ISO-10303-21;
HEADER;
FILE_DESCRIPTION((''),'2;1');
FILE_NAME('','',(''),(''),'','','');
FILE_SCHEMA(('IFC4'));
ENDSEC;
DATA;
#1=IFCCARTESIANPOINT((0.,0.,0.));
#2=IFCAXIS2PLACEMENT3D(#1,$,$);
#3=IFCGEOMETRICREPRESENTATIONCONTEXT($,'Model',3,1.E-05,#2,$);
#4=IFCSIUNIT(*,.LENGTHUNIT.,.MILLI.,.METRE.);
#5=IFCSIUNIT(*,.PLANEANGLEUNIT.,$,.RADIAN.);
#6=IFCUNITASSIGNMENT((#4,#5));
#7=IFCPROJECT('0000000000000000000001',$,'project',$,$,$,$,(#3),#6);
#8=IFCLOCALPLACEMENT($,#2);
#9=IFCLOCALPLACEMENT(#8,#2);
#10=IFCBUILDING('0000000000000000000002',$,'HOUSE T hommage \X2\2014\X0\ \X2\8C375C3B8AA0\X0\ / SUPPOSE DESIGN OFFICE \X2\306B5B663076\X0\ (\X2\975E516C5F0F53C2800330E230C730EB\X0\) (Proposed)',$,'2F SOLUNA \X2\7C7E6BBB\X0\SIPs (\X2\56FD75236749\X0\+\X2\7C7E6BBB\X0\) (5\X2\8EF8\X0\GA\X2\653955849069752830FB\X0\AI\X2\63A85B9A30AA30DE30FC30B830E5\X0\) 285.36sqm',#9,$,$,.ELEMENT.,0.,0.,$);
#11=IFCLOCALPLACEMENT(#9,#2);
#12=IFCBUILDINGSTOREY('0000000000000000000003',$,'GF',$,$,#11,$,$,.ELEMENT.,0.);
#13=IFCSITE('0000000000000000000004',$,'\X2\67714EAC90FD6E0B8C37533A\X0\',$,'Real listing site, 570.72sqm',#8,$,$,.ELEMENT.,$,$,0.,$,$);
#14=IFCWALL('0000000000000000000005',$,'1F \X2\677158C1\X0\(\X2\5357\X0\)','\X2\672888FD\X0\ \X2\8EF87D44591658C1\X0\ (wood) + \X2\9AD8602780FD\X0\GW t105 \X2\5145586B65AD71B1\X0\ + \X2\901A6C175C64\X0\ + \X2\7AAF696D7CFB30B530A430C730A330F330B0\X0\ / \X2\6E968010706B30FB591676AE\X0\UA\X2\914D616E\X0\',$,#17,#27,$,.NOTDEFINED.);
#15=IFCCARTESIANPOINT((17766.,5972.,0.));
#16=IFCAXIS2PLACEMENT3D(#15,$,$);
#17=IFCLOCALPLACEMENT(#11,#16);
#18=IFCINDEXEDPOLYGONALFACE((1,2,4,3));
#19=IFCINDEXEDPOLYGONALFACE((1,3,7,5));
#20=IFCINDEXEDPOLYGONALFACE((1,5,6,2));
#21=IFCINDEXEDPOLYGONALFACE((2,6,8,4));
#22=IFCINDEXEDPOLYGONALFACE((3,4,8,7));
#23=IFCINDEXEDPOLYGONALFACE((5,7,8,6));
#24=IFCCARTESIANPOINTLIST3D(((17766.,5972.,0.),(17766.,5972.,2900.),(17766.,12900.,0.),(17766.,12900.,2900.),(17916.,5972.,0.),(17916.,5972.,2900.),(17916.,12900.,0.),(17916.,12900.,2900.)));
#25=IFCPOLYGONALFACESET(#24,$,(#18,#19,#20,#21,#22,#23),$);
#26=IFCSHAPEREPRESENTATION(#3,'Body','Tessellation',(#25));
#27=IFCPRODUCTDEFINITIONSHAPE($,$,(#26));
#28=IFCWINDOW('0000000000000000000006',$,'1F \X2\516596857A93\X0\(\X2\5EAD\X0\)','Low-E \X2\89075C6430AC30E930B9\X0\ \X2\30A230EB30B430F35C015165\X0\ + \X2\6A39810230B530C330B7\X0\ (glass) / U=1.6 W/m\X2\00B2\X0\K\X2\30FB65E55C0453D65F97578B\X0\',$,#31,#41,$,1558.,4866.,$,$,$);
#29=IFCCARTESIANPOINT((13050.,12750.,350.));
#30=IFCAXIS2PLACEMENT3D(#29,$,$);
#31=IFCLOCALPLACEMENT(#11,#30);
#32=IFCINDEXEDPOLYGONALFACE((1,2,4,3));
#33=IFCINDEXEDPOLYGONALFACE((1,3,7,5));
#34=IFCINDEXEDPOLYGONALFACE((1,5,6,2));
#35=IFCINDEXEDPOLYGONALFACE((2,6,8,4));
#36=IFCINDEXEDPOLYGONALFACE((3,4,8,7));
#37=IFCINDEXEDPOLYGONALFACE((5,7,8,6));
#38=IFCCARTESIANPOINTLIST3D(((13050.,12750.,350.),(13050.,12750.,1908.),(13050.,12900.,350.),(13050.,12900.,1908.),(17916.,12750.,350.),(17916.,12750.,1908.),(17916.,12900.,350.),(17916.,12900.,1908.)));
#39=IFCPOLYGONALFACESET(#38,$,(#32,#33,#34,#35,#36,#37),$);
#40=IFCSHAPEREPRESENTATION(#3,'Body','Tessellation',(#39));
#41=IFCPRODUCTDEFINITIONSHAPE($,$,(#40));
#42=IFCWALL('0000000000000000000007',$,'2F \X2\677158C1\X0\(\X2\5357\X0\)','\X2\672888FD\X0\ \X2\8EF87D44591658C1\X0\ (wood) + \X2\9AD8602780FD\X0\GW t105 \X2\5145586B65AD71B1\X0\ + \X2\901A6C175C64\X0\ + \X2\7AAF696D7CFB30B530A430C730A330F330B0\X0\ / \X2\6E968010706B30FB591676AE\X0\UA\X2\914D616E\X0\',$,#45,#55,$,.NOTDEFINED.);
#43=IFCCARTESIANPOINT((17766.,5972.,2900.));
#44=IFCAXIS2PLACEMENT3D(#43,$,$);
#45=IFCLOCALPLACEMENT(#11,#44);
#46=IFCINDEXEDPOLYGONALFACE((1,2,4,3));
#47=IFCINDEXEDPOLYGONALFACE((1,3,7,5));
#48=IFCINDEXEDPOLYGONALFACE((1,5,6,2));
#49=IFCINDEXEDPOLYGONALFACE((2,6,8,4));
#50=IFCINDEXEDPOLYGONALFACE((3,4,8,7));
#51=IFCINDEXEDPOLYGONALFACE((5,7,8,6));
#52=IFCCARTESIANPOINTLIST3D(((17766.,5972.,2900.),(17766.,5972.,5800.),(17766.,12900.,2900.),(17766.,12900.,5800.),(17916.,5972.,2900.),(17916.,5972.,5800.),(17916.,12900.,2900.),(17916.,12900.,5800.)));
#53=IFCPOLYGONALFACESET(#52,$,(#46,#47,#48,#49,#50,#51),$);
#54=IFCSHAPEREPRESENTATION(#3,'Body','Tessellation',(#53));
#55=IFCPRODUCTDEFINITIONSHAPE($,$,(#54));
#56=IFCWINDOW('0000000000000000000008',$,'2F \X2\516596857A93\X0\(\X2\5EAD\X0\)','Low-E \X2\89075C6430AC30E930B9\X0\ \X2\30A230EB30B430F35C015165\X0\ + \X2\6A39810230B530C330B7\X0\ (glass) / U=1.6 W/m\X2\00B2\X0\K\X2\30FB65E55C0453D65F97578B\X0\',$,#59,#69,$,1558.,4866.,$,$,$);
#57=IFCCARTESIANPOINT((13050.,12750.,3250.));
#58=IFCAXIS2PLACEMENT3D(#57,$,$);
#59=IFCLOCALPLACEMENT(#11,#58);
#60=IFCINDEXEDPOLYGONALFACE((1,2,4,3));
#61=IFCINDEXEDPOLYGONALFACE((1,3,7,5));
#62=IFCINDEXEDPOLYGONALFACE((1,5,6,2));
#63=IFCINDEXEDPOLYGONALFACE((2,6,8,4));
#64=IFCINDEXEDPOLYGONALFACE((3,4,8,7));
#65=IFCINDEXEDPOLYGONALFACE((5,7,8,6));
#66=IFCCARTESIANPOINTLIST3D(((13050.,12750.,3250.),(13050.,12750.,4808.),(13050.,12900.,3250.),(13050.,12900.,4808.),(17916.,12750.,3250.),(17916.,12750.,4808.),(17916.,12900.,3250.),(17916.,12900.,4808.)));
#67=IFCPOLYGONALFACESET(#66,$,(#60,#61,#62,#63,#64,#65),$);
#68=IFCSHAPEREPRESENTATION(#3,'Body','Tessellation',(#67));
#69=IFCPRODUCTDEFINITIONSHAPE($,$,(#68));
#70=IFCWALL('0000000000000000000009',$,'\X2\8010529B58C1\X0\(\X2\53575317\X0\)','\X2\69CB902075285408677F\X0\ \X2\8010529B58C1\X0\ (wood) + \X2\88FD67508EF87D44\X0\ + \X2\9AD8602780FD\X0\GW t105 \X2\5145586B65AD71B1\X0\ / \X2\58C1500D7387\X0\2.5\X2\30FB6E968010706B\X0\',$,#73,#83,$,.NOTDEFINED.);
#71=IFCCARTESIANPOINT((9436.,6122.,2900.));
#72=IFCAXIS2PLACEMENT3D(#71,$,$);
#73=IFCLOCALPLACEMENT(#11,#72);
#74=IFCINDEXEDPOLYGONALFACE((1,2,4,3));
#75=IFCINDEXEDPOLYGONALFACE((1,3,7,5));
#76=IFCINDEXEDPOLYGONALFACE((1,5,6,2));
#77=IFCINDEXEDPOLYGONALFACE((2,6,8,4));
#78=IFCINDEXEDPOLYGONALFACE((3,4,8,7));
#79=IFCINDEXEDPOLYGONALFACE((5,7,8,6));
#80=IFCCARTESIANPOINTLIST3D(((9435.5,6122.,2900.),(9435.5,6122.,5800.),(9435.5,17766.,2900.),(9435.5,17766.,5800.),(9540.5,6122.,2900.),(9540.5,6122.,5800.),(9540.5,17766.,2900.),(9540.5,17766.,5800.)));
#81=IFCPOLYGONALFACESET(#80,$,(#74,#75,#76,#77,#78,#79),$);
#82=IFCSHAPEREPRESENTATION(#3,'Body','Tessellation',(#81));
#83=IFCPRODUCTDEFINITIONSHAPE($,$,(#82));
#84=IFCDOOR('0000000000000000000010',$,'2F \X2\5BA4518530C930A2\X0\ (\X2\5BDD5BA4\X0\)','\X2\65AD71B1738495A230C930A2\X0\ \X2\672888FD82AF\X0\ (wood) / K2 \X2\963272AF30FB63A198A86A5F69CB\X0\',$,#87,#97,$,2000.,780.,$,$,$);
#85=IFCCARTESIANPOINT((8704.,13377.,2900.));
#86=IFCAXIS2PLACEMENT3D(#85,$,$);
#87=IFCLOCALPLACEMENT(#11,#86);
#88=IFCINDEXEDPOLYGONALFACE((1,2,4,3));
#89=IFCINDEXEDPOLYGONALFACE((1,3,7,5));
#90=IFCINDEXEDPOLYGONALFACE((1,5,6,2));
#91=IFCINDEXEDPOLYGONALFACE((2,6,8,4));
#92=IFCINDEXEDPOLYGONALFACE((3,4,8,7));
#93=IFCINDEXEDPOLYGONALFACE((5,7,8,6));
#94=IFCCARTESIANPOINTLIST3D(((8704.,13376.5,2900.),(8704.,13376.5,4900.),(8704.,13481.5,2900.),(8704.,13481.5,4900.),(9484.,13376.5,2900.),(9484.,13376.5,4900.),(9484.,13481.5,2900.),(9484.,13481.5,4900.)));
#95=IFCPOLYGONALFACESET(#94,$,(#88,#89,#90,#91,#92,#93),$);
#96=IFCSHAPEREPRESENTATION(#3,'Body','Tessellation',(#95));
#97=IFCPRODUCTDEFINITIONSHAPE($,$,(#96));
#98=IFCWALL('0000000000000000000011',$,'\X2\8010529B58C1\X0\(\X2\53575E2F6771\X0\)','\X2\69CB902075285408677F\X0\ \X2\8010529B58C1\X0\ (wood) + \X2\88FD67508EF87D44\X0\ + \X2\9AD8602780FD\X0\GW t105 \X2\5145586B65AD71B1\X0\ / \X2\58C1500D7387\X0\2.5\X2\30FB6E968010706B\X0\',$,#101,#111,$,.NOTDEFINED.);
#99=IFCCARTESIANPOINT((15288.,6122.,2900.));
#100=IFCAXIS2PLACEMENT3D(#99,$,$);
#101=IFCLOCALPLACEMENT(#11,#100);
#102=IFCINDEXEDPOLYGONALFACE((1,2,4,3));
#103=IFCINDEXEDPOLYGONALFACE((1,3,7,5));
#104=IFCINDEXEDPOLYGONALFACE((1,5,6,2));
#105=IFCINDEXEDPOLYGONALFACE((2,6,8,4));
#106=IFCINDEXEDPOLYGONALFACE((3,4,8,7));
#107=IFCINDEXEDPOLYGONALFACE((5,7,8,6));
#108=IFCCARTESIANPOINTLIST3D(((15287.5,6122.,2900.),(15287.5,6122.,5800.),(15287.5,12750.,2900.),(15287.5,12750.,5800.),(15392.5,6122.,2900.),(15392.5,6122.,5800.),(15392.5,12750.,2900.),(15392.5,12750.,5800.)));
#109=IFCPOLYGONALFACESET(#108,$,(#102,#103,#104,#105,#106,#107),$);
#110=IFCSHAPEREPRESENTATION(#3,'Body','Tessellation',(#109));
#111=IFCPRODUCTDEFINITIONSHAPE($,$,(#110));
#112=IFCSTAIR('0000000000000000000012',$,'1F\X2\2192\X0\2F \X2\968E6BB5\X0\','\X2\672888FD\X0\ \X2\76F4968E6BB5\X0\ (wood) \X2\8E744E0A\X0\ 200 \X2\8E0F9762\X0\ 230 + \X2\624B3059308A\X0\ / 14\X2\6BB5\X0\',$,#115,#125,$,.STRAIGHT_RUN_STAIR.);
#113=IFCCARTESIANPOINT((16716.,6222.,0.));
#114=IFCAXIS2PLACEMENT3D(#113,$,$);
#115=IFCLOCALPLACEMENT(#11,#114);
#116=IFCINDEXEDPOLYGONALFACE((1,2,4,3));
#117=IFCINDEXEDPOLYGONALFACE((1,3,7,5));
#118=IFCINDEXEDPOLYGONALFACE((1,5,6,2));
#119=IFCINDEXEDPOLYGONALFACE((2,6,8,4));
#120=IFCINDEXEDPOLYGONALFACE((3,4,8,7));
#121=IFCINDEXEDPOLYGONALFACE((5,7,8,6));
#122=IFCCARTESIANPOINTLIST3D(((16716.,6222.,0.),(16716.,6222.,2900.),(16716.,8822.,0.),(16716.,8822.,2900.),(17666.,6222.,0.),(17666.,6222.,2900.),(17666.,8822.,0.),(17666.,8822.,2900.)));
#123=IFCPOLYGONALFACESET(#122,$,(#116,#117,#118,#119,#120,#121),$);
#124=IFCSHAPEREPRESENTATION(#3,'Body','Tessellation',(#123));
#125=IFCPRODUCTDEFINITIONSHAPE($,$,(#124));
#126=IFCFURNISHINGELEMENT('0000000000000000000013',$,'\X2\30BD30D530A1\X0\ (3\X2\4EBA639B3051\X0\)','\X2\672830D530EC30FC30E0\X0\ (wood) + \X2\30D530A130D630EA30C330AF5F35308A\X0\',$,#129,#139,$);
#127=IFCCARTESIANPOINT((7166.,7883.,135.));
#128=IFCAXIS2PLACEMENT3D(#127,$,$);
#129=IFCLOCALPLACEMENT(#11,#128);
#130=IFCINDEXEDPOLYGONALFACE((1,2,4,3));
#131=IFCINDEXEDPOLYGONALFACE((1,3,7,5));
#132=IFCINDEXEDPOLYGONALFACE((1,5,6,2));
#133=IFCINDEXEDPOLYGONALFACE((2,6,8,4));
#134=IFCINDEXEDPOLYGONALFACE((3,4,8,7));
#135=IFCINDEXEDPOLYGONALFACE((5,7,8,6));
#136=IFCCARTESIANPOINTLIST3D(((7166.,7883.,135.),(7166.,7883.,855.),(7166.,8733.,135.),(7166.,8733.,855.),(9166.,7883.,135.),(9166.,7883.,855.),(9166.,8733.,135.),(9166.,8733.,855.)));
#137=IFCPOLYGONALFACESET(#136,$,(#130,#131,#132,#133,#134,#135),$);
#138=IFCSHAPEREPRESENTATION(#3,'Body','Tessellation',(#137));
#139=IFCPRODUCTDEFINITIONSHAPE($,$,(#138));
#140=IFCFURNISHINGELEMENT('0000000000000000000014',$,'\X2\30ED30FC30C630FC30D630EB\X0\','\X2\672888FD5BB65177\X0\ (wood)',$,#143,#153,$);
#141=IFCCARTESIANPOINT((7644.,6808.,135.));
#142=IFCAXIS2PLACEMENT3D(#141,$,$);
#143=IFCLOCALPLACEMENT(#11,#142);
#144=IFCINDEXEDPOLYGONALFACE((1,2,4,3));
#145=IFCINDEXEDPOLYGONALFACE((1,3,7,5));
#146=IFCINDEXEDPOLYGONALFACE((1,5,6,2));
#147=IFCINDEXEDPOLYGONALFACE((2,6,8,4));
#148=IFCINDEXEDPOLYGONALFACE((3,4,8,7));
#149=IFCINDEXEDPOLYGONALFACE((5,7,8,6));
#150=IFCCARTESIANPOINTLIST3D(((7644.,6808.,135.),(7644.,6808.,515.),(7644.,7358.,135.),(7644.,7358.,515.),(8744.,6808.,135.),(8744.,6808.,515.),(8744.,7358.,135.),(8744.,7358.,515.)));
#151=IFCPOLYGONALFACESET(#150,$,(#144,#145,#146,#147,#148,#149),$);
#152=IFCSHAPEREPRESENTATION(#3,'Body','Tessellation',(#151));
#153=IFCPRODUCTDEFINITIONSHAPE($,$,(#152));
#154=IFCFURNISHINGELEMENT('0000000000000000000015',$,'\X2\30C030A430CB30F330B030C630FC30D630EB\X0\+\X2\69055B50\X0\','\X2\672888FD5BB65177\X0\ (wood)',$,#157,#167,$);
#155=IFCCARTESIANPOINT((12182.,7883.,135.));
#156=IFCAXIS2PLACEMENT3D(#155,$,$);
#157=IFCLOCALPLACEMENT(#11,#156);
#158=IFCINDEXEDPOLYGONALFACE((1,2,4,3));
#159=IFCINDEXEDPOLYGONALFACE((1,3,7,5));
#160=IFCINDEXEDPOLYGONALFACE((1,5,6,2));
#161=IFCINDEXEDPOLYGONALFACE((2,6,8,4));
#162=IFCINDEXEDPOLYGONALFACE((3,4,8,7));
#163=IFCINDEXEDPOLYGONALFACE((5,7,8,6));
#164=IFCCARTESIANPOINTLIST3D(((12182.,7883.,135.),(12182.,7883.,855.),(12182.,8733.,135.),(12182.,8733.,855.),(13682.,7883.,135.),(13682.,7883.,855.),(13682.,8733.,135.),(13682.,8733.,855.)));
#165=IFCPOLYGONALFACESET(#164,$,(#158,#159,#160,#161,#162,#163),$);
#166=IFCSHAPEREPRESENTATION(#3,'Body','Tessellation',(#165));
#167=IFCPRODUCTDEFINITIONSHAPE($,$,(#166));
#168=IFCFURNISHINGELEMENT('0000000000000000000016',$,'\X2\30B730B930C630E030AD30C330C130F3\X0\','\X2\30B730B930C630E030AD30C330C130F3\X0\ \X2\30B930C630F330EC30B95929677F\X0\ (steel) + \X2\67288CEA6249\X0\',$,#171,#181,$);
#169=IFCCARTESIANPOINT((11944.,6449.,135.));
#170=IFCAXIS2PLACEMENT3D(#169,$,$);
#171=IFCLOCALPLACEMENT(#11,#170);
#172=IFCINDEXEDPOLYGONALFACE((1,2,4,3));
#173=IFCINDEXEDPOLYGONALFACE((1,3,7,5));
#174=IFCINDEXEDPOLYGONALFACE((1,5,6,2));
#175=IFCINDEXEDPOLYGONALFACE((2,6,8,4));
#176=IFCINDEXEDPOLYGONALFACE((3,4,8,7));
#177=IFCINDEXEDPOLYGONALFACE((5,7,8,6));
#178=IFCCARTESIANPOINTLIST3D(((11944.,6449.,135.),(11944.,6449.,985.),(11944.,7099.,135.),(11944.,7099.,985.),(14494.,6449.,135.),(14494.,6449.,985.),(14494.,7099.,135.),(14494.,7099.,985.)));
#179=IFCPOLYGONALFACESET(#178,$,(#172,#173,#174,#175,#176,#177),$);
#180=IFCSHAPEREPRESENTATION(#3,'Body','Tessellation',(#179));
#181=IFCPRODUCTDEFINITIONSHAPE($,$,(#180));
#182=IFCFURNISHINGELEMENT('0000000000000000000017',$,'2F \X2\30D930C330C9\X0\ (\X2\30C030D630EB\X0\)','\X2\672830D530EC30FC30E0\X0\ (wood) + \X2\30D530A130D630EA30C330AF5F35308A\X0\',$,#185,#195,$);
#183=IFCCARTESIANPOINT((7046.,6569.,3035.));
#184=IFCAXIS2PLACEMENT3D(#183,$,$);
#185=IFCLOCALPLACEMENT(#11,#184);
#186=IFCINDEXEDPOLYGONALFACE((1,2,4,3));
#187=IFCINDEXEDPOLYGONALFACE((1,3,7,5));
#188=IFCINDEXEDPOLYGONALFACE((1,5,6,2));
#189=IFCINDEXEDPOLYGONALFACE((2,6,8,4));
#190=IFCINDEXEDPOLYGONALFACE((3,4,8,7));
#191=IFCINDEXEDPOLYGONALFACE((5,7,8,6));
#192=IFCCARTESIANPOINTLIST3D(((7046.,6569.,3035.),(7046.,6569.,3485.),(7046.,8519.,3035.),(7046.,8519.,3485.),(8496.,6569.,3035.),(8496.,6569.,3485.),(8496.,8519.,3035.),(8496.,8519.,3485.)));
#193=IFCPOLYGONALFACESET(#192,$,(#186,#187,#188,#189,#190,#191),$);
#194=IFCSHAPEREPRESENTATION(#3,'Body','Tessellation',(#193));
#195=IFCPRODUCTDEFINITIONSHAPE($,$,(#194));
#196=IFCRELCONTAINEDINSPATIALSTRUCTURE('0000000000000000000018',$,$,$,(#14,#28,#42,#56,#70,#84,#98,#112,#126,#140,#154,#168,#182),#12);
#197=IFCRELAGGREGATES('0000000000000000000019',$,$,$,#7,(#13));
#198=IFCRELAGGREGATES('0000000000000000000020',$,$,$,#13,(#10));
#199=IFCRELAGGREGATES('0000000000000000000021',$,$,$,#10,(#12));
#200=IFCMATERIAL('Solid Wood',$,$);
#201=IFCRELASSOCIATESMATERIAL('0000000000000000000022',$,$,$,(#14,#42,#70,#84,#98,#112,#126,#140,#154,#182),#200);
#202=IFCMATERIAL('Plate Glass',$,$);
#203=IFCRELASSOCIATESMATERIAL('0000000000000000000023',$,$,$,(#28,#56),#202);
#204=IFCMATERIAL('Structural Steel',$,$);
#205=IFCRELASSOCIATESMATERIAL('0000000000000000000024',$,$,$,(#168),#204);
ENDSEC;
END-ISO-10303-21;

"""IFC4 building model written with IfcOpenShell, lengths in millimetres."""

from ifc_helpers import new_model, si_unit, frame, frame_2d, origin, place, context, project, spatial, rectangle, extrude, material, element, fill, save


model = new_model("IFC4")

# Units and contexts
model_context = context("Model", 3, precision=1e-05, world=origin())
ifc_project = project(units=[si_unit("LENGTHUNIT", "METRE", prefix="MILLI"), si_unit("PLANEANGLEUNIT", "RADIAN")], contexts=[model_context])

# Site, building, storey
site_placement = place(None, origin())
site = spatial("IfcSite", under=ifc_project, at=site_placement, Name="東京都渋谷区", ObjectType="Real listing site, 570.72sqm", CompositionType="ELEMENT", RefElevation=0.0)
building_placement = place(site_placement, origin())
building = spatial("IfcBuilding", under=site, at=building_placement, Name="HOUSE T hommage — 谷尻誠 / SUPPOSE DESIGN OFFICE に学ぶ (非公式参考モデル) (Proposed)", ObjectType="2F SOLUNA 籾殻SIPs (国産杉+籾殻) (5軸GA改善適用・AI推定オマージュ) 285.36sqm", CompositionType="ELEMENT", ElevationOfRefHeight=0.0, ElevationOfTerrain=0.0)
storey_placement = place(building_placement, origin())
storey = spatial("IfcBuildingStorey", under=building, at=storey_placement, Name="GF", CompositionType="ELEMENT", Elevation=0.0)

# Wall, opening, window
ifc_material_1 = material(Name="Solid Wood")
wall_1_placement = place(storey_placement, frame((17766.0, 5972.0, 0.0)))
wall_1 = element("IfcWall", 1, at=wall_1_placement, inside=storey, material=ifc_material_1, Name="1F 東壁(南)", Description="木製 軸組外壁 (wood) + 高性能GW t105 充填断熱 + 通気層 + 窯業系サイディング / 準耐火・外皮UA配慮", PredefinedType="NOTDEFINED", context=model_context, shape_type="SweptSolid", body=[
    extrude(rectangle(XDim=150.0, YDim=6928.0, at=frame_2d((75.0, 3464.0))), frame((17766.0, 5972.0, 0.0)), (0.0, 0.0, 1.0), 2900.0),
])
opening_1_placement = place(storey_placement, frame((13050.0, 12750.0, 350.0)))
opening_1 = element("IfcOpeningElement", 2, at=opening_1_placement, cuts=wall_1, PredefinedType="NOTDEFINED", context=model_context, shape_type="SweptSolid", body=[
    extrude(rectangle(XDim=4866.0, YDim=150.0, at=frame_2d((2433.0, 75.0))), frame((13050.0, 12750.0, 350.0)), (0.0, 0.0, 1.0), 1558.0),
])
ifc_material_2 = material(Name="Plate Glass")
window_1_placement = place(storey_placement, frame((13050.0, 12750.0, 350.0)))
window_1 = element("IfcWindow", 3, at=window_1_placement, inside=storey, material=ifc_material_2, Name="1F 入隅窓(庭)", Description="Low-E 複層ガラス アルゴン封入 + 樹脂サッシ (glass) / U=1.6 W/m²K・日射取得型", OverallHeight=1558.0, OverallWidth=4866.0, context=model_context, shape_type="SweptSolid", body=[
    extrude(rectangle(XDim=4866.0, YDim=150.0, at=frame_2d((2433.0, 75.0))), frame((13050.0, 12750.0, 350.0)), (0.0, 0.0, 1.0), 1558.0),
])
fill(opening_1, window_1)

# Wall, opening, window
wall_2_placement = place(storey_placement, frame((17766.0, 5972.0, 2900.0)))
wall_2 = element("IfcWall", 4, at=wall_2_placement, inside=storey, material=ifc_material_1, Name="2F 東壁(南)", Description="木製 軸組外壁 (wood) + 高性能GW t105 充填断熱 + 通気層 + 窯業系サイディング / 準耐火・外皮UA配慮", PredefinedType="NOTDEFINED", context=model_context, shape_type="SweptSolid", body=[
    extrude(rectangle(XDim=150.0, YDim=6928.0, at=frame_2d((75.0, 3464.0))), frame((17766.0, 5972.0, 2900.0)), (0.0, 0.0, 1.0), 2900.0),
])
opening_2_placement = place(storey_placement, frame((13050.0, 12750.0, 3250.0)))
opening_2 = element("IfcOpeningElement", 5, at=opening_2_placement, cuts=wall_2, PredefinedType="NOTDEFINED", context=model_context, shape_type="SweptSolid", body=[
    extrude(rectangle(XDim=4866.0, YDim=150.0, at=frame_2d((2433.0, 75.0))), frame((13050.0, 12750.0, 3250.0)), (0.0, 0.0, 1.0), 1558.0),
])
window_2_placement = place(storey_placement, frame((13050.0, 12750.0, 3250.0)))
window_2 = element("IfcWindow", 6, at=window_2_placement, inside=storey, material=ifc_material_2, Name="2F 入隅窓(庭)", Description="Low-E 複層ガラス アルゴン封入 + 樹脂サッシ (glass) / U=1.6 W/m²K・日射取得型", OverallHeight=1558.0, OverallWidth=4866.0, context=model_context, shape_type="SweptSolid", body=[
    extrude(rectangle(XDim=4866.0, YDim=150.0, at=frame_2d((2433.0, 75.0))), frame((13050.0, 12750.0, 3250.0)), (0.0, 0.0, 1.0), 1558.0),
])
fill(opening_2, window_2)

# Wall, opening, door
wall_3_placement = place(storey_placement, frame((9436.0, 6122.0, 2900.0)))
wall_3 = element("IfcWall", 7, at=wall_3_placement, inside=storey, material=ifc_material_1, Name="耐力壁(南北)", Description="構造用合板 耐力壁 (wood) + 製材軸組 + 高性能GW t105 充填断熱 / 壁倍率2.5・準耐火", PredefinedType="NOTDEFINED", context=model_context, shape_type="SweptSolid", body=[
    extrude(rectangle(XDim=105.0, YDim=11644.0, at=frame_2d((52.0, 5822.0))), frame((9436.0, 6122.0, 2900.0)), (0.0, 0.0, 1.0), 2900.0),
])
opening_3_placement = place(storey_placement, frame((8704.0, 13377.0, 2900.0)))
opening_3 = element("IfcOpeningElement", 8, at=opening_3_placement, cuts=wall_3, PredefinedType="NOTDEFINED", context=model_context, shape_type="SweptSolid", body=[
    extrude(rectangle(XDim=780.0, YDim=105.0, at=frame_2d((390.0, 52.0))), frame((8704.0, 13377.0, 2900.0)), (0.0, 0.0, 1.0), 2000.0),
])
door_1_placement = place(storey_placement, frame((8704.0, 13377.0, 2900.0)))
door_1 = element("IfcDoor", 9, at=door_1_placement, inside=storey, material=ifc_material_1, Name="2F 室内ドア (寝室)", Description="断熱玄関ドア 木製芯 (wood) / K2 防犯・採風機構", OverallHeight=2000.0, OverallWidth=780.0, context=model_context, shape_type="SweptSolid", body=[
    extrude(rectangle(XDim=780.0, YDim=105.0, at=frame_2d((390.0, 52.0))), frame((8704.0, 13377.0, 2900.0)), (0.0, 0.0, 1.0), 2000.0),
])
fill(opening_3, door_1)

# Wall
wall_4_placement = place(storey_placement, frame((15288.0, 6122.0, 2900.0)))
element("IfcWall", 10, at=wall_4_placement, inside=storey, material=ifc_material_1, Name="耐力壁(南帯東)", Description="構造用合板 耐力壁 (wood) + 製材軸組 + 高性能GW t105 充填断熱 / 壁倍率2.5・準耐火", PredefinedType="NOTDEFINED", context=model_context, shape_type="SweptSolid", body=[
    extrude(rectangle(XDim=105.0, YDim=6628.0, at=frame_2d((52.0, 3314.0))), frame((15288.0, 6122.0, 2900.0)), (0.0, 0.0, 1.0), 2900.0),
])

# Stair
stair_placement = place(storey_placement, frame((16716.0, 6222.0, 0.0)))
element("IfcStair", 11, at=stair_placement, inside=storey, material=ifc_material_1, Name="1F→2F 階段", Description="木製 直階段 (wood) 蹴上 200 踏面 230 + 手すり / 14段", PredefinedType="STRAIGHT_RUN_STAIR", context=model_context, shape_type="SweptSolid", body=[
    extrude(rectangle(XDim=950.0, YDim=2600.0, at=frame_2d((475.0, 1300.0))), frame((16716.0, 6222.0, 0.0)), (0.0, 0.0, 1.0), 2900.0),
])

# Furnishing elements
furnishing_1_placement = place(storey_placement, frame((7166.0, 7883.0, 135.0)))
element("IfcFurnishingElement", 12, at=furnishing_1_placement, inside=storey, material=ifc_material_1, Name="ソファ (3人掛け)", Description="木フレーム (wood) + ファブリック張り", context=model_context, shape_type="SweptSolid", body=[
    extrude(rectangle(XDim=2000.0, YDim=850.0, at=frame_2d((1000.0, 425.0))), frame((7166.0, 7883.0, 135.0)), (0.0, 0.0, 1.0), 720.0),
])
furnishing_2_placement = place(storey_placement, frame((7644.0, 6808.0, 135.0)))
element("IfcFurnishingElement", 13, at=furnishing_2_placement, inside=storey, material=ifc_material_1, Name="ローテーブル", Description="木製家具 (wood)", context=model_context, shape_type="SweptSolid", body=[
    extrude(rectangle(XDim=1100.0, YDim=550.0, at=frame_2d((550.0, 275.0))), frame((7644.0, 6808.0, 135.0)), (0.0, 0.0, 1.0), 380.0),
])
furnishing_3_placement = place(storey_placement, frame((12182.0, 7883.0, 135.0)))
element("IfcFurnishingElement", 14, at=furnishing_3_placement, inside=storey, material=ifc_material_1, Name="ダイニングテーブル+椅子", Description="木製家具 (wood)", context=model_context, shape_type="SweptSolid", body=[
    extrude(rectangle(XDim=1500.0, YDim=850.0, at=frame_2d((750.0, 425.0))), frame((12182.0, 7883.0, 135.0)), (0.0, 0.0, 1.0), 720.0),
])
ifc_material_3 = material(Name="Structural Steel")
furnishing_4_placement = place(storey_placement, frame((11944.0, 6449.0, 135.0)))
element("IfcFurnishingElement", 15, at=furnishing_4_placement, inside=storey, material=ifc_material_3, Name="システムキッチン", Description="システムキッチン ステンレス天板 (steel) + 木質扉", context=model_context, shape_type="SweptSolid", body=[
    extrude(rectangle(XDim=2550.0, YDim=650.0, at=frame_2d((1275.0, 325.0))), frame((11944.0, 6449.0, 135.0)), (0.0, 0.0, 1.0), 850.0),
])
furnishing_5_placement = place(storey_placement, frame((7046.0, 6569.0, 3035.0)))
element("IfcFurnishingElement", 16, at=furnishing_5_placement, inside=storey, material=ifc_material_1, Name="2F ベッド (ダブル)", Description="木フレーム (wood) + ファブリック張り", context=model_context, shape_type="SweptSolid", body=[
    extrude(rectangle(XDim=1450.0, YDim=1950.0, at=frame_2d((725.0, 975.0))), frame((7046.0, 6569.0, 3035.0)), (0.0, 0.0, 1.0), 450.0),
])

save(model, "model.ifc")
